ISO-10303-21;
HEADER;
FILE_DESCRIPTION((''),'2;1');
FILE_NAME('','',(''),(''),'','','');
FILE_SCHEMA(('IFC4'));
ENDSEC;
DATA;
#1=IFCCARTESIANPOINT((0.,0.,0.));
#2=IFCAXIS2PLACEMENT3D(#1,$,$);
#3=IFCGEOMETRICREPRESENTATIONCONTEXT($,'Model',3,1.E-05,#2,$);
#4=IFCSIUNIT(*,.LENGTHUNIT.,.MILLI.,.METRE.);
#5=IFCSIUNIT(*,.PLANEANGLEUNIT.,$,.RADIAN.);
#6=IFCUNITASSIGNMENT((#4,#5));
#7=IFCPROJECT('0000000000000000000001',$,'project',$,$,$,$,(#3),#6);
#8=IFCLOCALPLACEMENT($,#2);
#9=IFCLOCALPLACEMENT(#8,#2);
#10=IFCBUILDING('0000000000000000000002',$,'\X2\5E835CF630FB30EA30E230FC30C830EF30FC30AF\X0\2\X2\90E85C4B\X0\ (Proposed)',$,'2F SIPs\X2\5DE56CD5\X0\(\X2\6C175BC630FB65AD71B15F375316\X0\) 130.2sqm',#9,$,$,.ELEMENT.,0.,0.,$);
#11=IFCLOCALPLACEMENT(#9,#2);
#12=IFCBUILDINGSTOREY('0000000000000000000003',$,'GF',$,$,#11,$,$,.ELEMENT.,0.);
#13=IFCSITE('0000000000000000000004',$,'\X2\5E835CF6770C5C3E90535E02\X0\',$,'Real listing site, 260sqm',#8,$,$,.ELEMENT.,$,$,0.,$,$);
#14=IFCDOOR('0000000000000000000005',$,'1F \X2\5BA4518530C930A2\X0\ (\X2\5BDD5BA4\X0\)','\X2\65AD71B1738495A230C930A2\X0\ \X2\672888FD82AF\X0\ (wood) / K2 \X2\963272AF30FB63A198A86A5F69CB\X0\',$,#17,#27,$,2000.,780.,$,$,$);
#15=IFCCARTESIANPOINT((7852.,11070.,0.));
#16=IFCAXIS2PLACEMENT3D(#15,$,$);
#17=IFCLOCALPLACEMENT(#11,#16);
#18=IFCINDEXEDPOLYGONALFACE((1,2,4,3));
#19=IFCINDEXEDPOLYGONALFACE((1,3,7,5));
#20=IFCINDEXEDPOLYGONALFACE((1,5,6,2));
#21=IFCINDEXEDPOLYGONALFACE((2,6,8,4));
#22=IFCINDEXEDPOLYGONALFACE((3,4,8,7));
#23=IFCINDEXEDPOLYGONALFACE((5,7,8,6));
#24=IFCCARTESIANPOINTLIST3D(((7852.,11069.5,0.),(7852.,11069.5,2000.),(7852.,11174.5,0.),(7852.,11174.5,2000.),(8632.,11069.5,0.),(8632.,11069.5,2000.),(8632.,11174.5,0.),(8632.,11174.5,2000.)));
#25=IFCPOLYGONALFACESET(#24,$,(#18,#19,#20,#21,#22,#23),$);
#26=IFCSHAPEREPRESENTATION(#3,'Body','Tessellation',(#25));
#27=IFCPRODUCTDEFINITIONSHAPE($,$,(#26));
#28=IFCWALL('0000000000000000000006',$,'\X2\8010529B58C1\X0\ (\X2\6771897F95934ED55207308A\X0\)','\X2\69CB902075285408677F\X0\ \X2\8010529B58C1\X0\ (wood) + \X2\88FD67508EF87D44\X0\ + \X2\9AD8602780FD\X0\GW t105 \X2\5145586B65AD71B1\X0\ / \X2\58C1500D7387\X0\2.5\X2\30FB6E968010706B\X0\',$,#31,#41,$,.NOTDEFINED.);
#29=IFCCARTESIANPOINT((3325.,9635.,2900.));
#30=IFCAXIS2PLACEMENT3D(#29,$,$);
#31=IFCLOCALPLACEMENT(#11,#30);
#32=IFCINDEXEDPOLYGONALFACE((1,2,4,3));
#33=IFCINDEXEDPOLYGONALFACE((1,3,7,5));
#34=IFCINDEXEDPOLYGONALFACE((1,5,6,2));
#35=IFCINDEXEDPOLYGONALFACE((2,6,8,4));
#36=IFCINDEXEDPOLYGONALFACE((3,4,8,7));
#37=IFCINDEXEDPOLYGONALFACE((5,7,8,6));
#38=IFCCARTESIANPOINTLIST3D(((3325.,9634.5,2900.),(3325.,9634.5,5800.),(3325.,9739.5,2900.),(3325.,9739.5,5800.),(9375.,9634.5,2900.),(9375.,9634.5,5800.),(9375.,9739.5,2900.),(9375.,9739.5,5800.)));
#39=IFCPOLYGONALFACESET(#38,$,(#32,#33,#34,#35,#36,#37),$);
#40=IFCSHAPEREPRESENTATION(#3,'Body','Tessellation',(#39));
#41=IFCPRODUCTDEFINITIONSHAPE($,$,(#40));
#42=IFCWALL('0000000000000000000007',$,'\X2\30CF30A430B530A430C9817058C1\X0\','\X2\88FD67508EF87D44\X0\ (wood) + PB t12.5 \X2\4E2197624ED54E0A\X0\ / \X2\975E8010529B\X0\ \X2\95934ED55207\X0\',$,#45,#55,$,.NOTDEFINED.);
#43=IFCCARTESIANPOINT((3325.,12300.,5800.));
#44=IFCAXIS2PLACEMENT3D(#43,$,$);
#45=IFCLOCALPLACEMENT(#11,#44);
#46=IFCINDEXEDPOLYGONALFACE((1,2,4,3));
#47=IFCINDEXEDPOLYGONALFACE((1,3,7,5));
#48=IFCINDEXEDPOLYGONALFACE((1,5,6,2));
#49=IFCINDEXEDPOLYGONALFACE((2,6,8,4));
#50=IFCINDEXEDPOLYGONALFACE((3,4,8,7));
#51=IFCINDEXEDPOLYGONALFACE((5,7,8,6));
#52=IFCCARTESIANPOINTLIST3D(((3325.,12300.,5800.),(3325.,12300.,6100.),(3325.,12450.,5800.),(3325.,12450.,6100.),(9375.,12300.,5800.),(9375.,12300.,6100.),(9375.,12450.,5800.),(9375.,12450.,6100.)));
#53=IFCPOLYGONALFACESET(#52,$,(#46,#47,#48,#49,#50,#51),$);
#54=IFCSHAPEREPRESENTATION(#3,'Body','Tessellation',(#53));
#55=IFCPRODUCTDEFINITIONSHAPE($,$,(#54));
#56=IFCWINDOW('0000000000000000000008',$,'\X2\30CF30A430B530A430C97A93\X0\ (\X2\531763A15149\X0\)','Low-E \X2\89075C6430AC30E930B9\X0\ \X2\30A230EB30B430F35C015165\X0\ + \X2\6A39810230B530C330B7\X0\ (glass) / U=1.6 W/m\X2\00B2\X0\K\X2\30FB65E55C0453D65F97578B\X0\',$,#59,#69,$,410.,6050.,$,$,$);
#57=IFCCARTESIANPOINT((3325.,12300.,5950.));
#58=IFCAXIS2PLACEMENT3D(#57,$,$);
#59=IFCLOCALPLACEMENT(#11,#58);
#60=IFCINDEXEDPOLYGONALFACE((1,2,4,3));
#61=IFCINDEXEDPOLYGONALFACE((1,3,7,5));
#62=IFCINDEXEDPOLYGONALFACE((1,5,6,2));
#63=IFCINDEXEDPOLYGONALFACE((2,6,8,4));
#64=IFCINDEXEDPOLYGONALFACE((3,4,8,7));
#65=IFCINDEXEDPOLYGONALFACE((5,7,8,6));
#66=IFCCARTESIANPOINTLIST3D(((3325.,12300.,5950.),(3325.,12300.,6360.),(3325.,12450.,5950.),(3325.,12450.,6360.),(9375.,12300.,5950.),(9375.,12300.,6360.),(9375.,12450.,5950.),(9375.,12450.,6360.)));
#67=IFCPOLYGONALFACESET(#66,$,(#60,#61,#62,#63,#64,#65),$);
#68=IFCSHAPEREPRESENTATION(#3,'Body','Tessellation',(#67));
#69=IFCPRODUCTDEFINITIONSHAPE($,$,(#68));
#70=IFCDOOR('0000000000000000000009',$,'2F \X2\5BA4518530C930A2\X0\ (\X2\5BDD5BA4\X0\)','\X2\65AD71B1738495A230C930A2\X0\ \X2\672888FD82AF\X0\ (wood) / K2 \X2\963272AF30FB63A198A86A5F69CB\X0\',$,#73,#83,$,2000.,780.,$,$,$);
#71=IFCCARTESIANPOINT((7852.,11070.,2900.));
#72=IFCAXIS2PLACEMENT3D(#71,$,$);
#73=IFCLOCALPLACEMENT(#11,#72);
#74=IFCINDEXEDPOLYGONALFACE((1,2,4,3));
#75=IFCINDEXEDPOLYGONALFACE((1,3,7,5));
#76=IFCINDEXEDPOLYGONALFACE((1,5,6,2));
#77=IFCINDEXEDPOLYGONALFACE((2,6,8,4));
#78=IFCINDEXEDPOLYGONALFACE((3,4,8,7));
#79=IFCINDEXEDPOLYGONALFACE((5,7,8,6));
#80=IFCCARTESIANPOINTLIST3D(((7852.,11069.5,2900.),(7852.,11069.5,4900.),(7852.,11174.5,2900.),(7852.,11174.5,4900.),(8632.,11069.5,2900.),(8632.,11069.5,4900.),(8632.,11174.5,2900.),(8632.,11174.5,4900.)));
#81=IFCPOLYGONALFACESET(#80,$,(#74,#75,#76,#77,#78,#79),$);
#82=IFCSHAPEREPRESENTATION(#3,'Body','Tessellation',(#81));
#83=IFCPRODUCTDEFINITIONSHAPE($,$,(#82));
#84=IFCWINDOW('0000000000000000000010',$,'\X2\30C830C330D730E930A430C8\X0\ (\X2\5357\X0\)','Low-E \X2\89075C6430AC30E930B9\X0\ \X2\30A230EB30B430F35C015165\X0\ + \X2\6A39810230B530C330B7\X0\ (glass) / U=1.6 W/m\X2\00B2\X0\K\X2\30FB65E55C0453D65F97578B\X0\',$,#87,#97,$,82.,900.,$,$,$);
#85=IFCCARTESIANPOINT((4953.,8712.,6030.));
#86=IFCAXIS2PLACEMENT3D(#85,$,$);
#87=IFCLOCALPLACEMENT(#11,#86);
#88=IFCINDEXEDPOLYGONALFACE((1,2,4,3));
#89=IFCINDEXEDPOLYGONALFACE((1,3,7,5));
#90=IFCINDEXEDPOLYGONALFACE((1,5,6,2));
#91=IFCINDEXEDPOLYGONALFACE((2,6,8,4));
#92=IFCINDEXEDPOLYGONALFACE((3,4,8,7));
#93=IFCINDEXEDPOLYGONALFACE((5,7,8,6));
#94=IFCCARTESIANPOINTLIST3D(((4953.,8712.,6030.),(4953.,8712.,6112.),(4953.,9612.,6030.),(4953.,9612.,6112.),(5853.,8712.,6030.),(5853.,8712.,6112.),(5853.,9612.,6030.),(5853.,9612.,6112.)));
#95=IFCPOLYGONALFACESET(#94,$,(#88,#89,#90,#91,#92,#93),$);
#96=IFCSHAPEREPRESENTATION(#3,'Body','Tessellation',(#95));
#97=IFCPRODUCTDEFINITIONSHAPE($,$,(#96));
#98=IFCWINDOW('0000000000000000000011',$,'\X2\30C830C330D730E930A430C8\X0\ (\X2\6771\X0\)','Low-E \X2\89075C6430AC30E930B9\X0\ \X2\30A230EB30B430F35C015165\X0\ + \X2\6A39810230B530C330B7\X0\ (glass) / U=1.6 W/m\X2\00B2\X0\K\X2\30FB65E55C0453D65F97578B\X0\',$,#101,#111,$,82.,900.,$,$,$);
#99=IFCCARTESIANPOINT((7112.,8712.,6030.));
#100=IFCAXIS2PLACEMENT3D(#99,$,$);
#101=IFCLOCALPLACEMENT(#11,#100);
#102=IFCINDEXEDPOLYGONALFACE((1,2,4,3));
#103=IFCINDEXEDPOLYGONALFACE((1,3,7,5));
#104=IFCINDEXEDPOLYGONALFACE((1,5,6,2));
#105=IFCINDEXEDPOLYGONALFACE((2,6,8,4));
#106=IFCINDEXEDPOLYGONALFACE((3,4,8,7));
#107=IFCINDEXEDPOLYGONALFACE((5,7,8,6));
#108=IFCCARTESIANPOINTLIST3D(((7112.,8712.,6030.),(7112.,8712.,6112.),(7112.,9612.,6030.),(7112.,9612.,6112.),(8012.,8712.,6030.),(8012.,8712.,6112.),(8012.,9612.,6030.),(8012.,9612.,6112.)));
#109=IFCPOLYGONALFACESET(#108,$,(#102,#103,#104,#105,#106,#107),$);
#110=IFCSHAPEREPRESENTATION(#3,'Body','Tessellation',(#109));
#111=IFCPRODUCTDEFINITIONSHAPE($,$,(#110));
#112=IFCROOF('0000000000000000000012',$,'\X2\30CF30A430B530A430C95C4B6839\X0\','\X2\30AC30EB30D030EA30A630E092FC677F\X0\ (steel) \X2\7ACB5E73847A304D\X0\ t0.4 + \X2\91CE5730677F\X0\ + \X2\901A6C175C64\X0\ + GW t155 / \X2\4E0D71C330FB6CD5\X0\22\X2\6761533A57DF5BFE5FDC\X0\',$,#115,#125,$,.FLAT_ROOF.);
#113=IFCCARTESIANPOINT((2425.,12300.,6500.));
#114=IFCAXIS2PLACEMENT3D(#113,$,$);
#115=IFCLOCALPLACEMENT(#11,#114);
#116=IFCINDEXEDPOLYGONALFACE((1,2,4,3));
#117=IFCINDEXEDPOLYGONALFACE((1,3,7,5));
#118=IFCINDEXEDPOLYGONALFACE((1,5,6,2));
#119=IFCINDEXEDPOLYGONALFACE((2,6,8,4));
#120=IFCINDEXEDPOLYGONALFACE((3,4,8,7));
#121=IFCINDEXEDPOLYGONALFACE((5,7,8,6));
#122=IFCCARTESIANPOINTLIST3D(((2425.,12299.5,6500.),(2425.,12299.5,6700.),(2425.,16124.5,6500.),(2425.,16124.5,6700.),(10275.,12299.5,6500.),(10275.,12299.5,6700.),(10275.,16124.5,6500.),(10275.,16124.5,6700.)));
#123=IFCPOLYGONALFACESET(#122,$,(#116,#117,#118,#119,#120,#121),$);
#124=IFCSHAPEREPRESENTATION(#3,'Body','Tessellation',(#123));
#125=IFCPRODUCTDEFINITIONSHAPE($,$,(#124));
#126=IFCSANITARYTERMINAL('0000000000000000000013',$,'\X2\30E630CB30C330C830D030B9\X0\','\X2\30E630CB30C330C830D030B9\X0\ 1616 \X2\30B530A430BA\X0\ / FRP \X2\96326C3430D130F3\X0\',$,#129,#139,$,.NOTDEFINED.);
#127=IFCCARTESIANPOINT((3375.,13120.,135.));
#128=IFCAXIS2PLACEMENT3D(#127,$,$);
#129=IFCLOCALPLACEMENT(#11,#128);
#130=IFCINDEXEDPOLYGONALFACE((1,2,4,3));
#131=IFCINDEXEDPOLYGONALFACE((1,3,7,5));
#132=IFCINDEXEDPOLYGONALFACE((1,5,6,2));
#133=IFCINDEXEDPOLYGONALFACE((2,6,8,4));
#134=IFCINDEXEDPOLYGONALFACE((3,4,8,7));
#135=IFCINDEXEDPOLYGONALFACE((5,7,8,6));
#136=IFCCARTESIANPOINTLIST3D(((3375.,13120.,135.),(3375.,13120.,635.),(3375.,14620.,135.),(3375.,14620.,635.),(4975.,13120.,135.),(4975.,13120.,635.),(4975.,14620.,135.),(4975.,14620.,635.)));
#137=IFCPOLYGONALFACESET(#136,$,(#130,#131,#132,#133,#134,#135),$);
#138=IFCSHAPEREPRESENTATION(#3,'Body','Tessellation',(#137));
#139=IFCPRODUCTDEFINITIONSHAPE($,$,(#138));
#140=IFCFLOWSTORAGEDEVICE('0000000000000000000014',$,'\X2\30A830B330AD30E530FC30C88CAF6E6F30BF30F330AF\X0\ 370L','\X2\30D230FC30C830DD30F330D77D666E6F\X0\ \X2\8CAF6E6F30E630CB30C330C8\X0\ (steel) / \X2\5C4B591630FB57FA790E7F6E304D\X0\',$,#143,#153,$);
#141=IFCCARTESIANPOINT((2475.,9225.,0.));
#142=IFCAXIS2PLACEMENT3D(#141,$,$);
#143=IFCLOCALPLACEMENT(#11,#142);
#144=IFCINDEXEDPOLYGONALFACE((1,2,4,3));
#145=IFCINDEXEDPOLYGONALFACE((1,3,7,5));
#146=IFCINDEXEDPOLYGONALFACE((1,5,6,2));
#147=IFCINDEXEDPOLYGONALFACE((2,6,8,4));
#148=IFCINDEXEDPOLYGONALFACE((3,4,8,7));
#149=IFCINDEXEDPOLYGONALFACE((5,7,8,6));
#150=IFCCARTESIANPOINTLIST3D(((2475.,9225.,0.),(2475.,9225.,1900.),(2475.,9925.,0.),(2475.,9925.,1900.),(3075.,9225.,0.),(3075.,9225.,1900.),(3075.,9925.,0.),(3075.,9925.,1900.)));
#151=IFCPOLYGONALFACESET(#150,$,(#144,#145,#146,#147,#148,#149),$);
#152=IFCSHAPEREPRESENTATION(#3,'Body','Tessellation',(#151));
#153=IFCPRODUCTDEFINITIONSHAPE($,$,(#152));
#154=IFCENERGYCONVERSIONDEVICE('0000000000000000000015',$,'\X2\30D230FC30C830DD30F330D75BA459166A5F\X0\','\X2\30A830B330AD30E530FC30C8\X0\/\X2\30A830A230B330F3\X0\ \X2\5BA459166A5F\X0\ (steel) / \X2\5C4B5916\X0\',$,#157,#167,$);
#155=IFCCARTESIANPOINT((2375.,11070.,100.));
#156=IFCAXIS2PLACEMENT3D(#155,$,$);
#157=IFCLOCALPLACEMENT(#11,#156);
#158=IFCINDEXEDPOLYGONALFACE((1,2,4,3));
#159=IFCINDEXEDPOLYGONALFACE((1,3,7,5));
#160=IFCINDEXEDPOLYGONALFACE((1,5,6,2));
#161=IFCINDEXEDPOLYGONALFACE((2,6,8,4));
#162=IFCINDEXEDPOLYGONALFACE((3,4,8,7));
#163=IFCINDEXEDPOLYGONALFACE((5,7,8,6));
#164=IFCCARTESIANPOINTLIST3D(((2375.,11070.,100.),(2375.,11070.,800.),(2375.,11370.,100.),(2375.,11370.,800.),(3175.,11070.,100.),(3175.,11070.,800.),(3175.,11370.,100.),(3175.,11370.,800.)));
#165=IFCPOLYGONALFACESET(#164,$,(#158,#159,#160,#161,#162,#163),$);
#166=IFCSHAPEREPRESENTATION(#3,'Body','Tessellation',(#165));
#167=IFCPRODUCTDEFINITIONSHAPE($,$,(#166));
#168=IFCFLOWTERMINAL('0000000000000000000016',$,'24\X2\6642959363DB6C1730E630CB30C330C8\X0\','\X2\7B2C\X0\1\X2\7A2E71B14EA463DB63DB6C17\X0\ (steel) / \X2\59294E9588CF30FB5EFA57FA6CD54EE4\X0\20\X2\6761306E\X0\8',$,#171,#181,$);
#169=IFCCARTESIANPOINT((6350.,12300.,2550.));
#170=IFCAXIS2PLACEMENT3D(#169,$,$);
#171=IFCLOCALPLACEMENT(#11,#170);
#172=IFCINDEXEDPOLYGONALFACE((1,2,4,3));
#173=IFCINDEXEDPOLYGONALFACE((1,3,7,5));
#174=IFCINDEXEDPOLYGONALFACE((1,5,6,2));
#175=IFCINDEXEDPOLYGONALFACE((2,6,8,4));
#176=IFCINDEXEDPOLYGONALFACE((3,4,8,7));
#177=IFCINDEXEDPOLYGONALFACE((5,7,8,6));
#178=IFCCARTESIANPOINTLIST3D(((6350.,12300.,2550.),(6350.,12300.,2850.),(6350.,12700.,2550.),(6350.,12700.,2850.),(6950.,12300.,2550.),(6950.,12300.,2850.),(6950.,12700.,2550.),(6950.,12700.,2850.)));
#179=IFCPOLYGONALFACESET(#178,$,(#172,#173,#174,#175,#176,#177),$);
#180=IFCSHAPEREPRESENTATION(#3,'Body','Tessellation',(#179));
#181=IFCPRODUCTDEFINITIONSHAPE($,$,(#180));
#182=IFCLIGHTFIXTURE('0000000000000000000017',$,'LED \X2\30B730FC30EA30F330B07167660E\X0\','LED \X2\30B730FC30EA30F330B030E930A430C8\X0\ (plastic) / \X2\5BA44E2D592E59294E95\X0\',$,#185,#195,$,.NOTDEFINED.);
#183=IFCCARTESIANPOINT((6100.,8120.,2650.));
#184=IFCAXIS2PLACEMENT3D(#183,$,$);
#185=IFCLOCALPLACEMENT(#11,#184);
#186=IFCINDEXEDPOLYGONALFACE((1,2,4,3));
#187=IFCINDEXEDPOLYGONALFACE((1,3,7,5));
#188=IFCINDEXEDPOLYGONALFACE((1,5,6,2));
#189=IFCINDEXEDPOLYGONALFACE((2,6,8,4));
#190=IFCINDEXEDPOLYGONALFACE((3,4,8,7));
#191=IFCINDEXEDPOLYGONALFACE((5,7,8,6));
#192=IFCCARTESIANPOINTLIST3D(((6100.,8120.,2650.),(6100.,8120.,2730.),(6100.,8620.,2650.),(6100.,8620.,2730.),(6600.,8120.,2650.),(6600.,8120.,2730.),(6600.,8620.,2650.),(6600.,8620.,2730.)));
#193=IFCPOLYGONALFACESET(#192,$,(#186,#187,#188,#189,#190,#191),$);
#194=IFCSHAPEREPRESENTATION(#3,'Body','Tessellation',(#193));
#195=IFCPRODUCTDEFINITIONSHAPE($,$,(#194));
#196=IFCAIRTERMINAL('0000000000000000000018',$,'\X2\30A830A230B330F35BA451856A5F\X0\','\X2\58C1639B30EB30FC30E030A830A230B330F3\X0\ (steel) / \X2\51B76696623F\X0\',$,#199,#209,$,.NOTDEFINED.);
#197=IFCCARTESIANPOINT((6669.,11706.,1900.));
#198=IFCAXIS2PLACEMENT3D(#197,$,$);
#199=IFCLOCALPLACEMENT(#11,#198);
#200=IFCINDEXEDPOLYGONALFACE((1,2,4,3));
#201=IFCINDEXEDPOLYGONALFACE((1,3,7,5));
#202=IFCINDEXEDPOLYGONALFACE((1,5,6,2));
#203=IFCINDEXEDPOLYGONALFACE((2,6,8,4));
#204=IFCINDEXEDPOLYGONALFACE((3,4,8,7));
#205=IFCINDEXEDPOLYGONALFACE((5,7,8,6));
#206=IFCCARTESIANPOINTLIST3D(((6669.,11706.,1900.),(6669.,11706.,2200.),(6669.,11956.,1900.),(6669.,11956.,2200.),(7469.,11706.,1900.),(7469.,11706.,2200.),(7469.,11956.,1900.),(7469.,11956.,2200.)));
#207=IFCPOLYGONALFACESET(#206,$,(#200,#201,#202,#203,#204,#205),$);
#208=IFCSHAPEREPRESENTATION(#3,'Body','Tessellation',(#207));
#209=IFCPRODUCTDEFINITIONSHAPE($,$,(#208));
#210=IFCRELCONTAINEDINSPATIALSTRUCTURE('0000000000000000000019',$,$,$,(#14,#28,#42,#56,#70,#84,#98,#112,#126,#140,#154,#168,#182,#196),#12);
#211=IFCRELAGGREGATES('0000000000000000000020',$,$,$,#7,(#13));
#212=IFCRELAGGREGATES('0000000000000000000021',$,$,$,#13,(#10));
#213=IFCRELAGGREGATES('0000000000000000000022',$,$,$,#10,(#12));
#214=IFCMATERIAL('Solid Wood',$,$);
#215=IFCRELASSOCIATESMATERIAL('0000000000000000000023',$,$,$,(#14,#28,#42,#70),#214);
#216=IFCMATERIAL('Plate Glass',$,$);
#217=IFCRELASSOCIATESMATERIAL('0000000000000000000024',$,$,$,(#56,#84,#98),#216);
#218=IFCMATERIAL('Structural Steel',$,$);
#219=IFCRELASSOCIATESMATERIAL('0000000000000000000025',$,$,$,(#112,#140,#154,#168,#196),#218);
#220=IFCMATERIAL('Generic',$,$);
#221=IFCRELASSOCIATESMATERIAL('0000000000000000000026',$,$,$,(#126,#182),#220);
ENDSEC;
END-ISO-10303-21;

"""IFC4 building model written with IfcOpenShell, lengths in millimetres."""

from ifc_helpers import new_model, si_unit, frame, frame_2d, origin, place, context, project, spatial, rectangle, extrude, material, element, fill, save


model = new_model("IFC4")

# Units and contexts
model_context = context("Model", 3, precision=1e-05, world=origin())
ifc_project = project(units=[si_unit("LENGTHUNIT", "METRE", prefix="MILLI"), si_unit("PLANEANGLEUNIT", "RADIAN")], contexts=[model_context])

# Site, building, storey
site_placement = place(None, origin())
site = spatial("IfcSite", under=ifc_project, at=site_placement, Name="広島県尾道市", ObjectType="Real listing site, 260sqm", CompositionType="ELEMENT", RefElevation=0.0)
building_placement = place(site_placement, origin())
building = spatial("IfcBuilding", under=site, at=building_placement, Name="広島・リモートワーク2部屋 (Proposed)", ObjectType="2F SIPs工法(気密・断熱強化) 130.2sqm", CompositionType="ELEMENT", ElevationOfRefHeight=0.0, ElevationOfTerrain=0.0)
storey_placement = place(building_placement, origin())
storey = spatial("IfcBuildingStorey", under=building, at=storey_placement, Name="GF", CompositionType="ELEMENT", Elevation=0.0)

# Shared definitions
ifc_material_1 = material(Name="Solid Wood")

# Door
door_1_placement = place(storey_placement, frame((7852.0, 11070.0, 0.0)))
element("IfcDoor", 1, at=door_1_placement, inside=storey, material=ifc_material_1, Name="1F 室内ドア (寝室)", Description="断熱玄関ドア 木製芯 (wood) / K2 防犯・採風機構", OverallHeight=2000.0, OverallWidth=780.0, context=model_context, shape_type="SweptSolid", body=[
    extrude(rectangle(XDim=780.0, YDim=105.0, at=frame_2d((390.0, 52.0))), frame((7852.0, 11070.0, 0.0)), (0.0, 0.0, 1.0), 2000.0),
])

# Wall
wall_1_placement = place(storey_placement, frame((3325.0, 9635.0, 2900.0)))
element("IfcWall", 2, at=wall_1_placement, inside=storey, material=ifc_material_1, Name="耐力壁 (東西間仕切り)", Description="構造用合板 耐力壁 (wood) + 製材軸組 + 高性能GW t105 充填断熱 / 壁倍率2.5・準耐火", PredefinedType="NOTDEFINED", context=model_context, shape_type="SweptSolid", body=[
    extrude(rectangle(XDim=6050.0, YDim=105.0, at=frame_2d((3025.0, 52.0))), frame((3325.0, 9635.0, 2900.0)), (0.0, 0.0, 1.0), 2900.0),
])

# Wall, opening, window
wall_2_placement = place(storey_placement, frame((3325.0, 12300.0, 5800.0)))
wall_2 = element("IfcWall", 3, at=wall_2_placement, inside=storey, material=ifc_material_1, Name="ハイサイド腰壁", Description="製材軸組 (wood) + PB t12.5 両面仕上 / 非耐力 間仕切", PredefinedType="NOTDEFINED", context=model_context, shape_type="SweptSolid", body=[
    extrude(rectangle(XDim=6050.0, YDim=150.0, at=frame_2d((3025.0, 75.0))), frame((3325.0, 12300.0, 5800.0)), (0.0, 0.0, 1.0), 700.0),
])
opening_1_placement = place(storey_placement, frame((3325.0, 12300.0, 5950.0)))
opening_1 = element("IfcOpeningElement", 4, at=opening_1_placement, cuts=wall_2, PredefinedType="NOTDEFINED", context=model_context, shape_type="SweptSolid", body=[
    extrude(rectangle(XDim=6050.0, YDim=150.0, at=frame_2d((3025.0, 75.0))), frame((3325.0, 12300.0, 5950.0)), (0.0, 0.0, 1.0), 410.0),
])
ifc_material_2 = material(Name="Plate Glass")
window_1_placement = place(storey_placement, frame((3325.0, 12300.0, 5950.0)))
window_1 = element("IfcWindow", 5, at=window_1_placement, inside=storey, material=ifc_material_2, Name="ハイサイド窓 (北採光)", Description="Low-E 複層ガラス アルゴン封入 + 樹脂サッシ (glass) / U=1.6 W/m²K・日射取得型", OverallHeight=410.0, OverallWidth=6050.0, context=model_context, shape_type="SweptSolid", body=[
    extrude(rectangle(XDim=6050.0, YDim=150.0, at=frame_2d((3025.0, 75.0))), frame((3325.0, 12300.0, 5950.0)), (0.0, 0.0, 1.0), 410.0),
])
fill(opening_1, window_1)

# Door
door_2_placement = place(storey_placement, frame((7852.0, 11070.0, 2900.0)))
element("IfcDoor", 6, at=door_2_placement, inside=storey, material=ifc_material_1, Name="2F 室内ドア (寝室)", Description="断熱玄関ドア 木製芯 (wood) / K2 防犯・採風機構", OverallHeight=2000.0, OverallWidth=780.0, context=model_context, shape_type="SweptSolid", body=[
    extrude(rectangle(XDim=780.0, YDim=105.0, at=frame_2d((390.0, 52.0))), frame((7852.0, 11070.0, 2900.0)), (0.0, 0.0, 1.0), 2000.0),
])

# Windows
window_2_placement = place(storey_placement, frame((4953.0, 8712.0, 6030.0)))
element("IfcWindow", 7, at=window_2_placement, inside=storey, material=ifc_material_2, Name="トップライト (南)", Description="Low-E 複層ガラス アルゴン封入 + 樹脂サッシ (glass) / U=1.6 W/m²K・日射取得型", OverallHeight=82.0, OverallWidth=900.0, context=model_context, shape_type="SweptSolid", body=[
    extrude(rectangle(XDim=900.0, YDim=900.0, at=frame_2d((450.0, 450.0))), frame((4953.0, 8712.0, 6030.0)), (0.0, 0.0, 1.0), 82.0),
])
window_3_placement = place(storey_placement, frame((7112.0, 8712.0, 6030.0)))
element("IfcWindow", 8, at=window_3_placement, inside=storey, material=ifc_material_2, Name="トップライト (東)", Description="Low-E 複層ガラス アルゴン封入 + 樹脂サッシ (glass) / U=1.6 W/m²K・日射取得型", OverallHeight=82.0, OverallWidth=900.0, context=model_context, shape_type="SweptSolid", body=[
    extrude(rectangle(XDim=900.0, YDim=900.0, at=frame_2d((450.0, 450.0))), frame((7112.0, 8712.0, 6030.0)), (0.0, 0.0, 1.0), 82.0),
])

# Roof
ifc_material_3 = material(Name="Structural Steel")
roof_placement = place(storey_placement, frame((2425.0, 12300.0, 6500.0)))
element("IfcRoof", 9, at=roof_placement, inside=storey, material=ifc_material_3, Name="ハイサイド屋根", Description="ガルバリウム鋼板 (steel) 立平葺き t0.4 + 野地板 + 通気層 + GW t155 / 不燃・法22条区域対応", PredefinedType="FLAT_ROOF", context=model_context, shape_type="SweptSolid", body=[
    extrude(rectangle(XDim=7850.0, YDim=3825.0, at=frame_2d((3925.0, 1912.0))), frame((2425.0, 12300.0, 6500.0)), (0.0, 0.0, 1.0), 200.0),
])

# Sanitary terminal
ifc_material_4 = material(Name="Generic")
sanitary_terminal_placement = place(storey_placement, frame((3375.0, 13120.0, 135.0)))
element("IfcSanitaryTerminal", 10, at=sanitary_terminal_placement, inside=storey, material=ifc_material_4, Name="ユニットバス", Description="ユニットバス 1616 サイズ / FRP 防水パン", PredefinedType="NOTDEFINED", context=model_context, shape_type="SweptSolid", body=[
    extrude(rectangle(XDim=1600.0, YDim=1500.0, at=frame_2d((800.0, 750.0))), frame((3375.0, 13120.0, 135.0)), (0.0, 0.0, 1.0), 500.0),
])

# Flow storage device
flow_storage_device_placement = place(storey_placement, frame((2475.0, 9225.0, 0.0)))
element("IfcFlowStorageDevice", 11, at=flow_storage_device_placement, inside=storey, material=ifc_material_3, Name="エコキュート貯湯タンク 370L", Description="ヒートポンプ給湯 貯湯ユニット (steel) / 屋外・基礎置き", context=model_context, shape_type="SweptSolid", body=[
    extrude(rectangle(XDim=600.0, YDim=700.0, at=frame_2d((300.0, 350.0))), frame((2475.0, 9225.0, 0.0)), (0.0, 0.0, 1.0), 1900.0),
])

# Energy conversion device
energy_conversion_device_placement = place(storey_placement, frame((2375.0, 11070.0, 100.0)))
element("IfcEnergyConversionDevice", 12, at=energy_conversion_device_placement, inside=storey, material=ifc_material_3, Name="ヒートポンプ室外機", Description="エコキュート/エアコン 室外機 (steel) / 屋外", context=model_context, shape_type="SweptSolid", body=[
    extrude(rectangle(XDim=800.0, YDim=300.0, at=frame_2d((400.0, 150.0))), frame((2375.0, 11070.0, 100.0)), (0.0, 0.0, 1.0), 700.0),
])

# Flow terminal
flow_terminal_placement = place(storey_placement, frame((6350.0, 12300.0, 2550.0)))
element("IfcFlowTerminal", 13, at=flow_terminal_placement, inside=storey, material=ifc_material_3, Name="24時間換気ユニット", Description="第1種熱交換換気 (steel) / 天井裏・建基法令20条の8", context=model_context, shape_type="SweptSolid", body=[
    extrude(rectangle(XDim=600.0, YDim=400.0, at=frame_2d((300.0, 200.0))), frame((6350.0, 12300.0, 2550.0)), (0.0, 0.0, 1.0), 300.0),
])

# Light fixture
light_fixture_1_placement = place(storey_placement, frame((6100.0, 8120.0, 2650.0)))
element("IfcLightFixture", 14, at=light_fixture_1_placement, inside=storey, material=ifc_material_4, Name="LED シーリング照明", Description="LED シーリングライト (plastic) / 室中央天井", PredefinedType="NOTDEFINED", context=model_context, shape_type="SweptSolid", body=[
    extrude(rectangle(XDim=500.0, YDim=500.0, at=frame_2d((250.0, 250.0))), frame((6100.0, 8120.0, 2650.0)), (0.0, 0.0, 1.0), 80.0),
])

# Air terminal
air_terminal_placement = place(storey_placement, frame((6669.0, 11706.0, 1900.0)))
element("IfcAirTerminal", 15, at=air_terminal_placement, inside=storey, material=ifc_material_3, Name="エアコン室内機", Description="壁掛ルームエアコン (steel) / 冷暖房", PredefinedType="NOTDEFINED", context=model_context, shape_type="SweptSolid", body=[
    extrude(rectangle(XDim=800.0, YDim=250.0, at=frame_2d((400.0, 125.0))), frame((6669.0, 11706.0, 1900.0)), (0.0, 0.0, 1.0), 300.0),
])

save(model, "model.ifc")
